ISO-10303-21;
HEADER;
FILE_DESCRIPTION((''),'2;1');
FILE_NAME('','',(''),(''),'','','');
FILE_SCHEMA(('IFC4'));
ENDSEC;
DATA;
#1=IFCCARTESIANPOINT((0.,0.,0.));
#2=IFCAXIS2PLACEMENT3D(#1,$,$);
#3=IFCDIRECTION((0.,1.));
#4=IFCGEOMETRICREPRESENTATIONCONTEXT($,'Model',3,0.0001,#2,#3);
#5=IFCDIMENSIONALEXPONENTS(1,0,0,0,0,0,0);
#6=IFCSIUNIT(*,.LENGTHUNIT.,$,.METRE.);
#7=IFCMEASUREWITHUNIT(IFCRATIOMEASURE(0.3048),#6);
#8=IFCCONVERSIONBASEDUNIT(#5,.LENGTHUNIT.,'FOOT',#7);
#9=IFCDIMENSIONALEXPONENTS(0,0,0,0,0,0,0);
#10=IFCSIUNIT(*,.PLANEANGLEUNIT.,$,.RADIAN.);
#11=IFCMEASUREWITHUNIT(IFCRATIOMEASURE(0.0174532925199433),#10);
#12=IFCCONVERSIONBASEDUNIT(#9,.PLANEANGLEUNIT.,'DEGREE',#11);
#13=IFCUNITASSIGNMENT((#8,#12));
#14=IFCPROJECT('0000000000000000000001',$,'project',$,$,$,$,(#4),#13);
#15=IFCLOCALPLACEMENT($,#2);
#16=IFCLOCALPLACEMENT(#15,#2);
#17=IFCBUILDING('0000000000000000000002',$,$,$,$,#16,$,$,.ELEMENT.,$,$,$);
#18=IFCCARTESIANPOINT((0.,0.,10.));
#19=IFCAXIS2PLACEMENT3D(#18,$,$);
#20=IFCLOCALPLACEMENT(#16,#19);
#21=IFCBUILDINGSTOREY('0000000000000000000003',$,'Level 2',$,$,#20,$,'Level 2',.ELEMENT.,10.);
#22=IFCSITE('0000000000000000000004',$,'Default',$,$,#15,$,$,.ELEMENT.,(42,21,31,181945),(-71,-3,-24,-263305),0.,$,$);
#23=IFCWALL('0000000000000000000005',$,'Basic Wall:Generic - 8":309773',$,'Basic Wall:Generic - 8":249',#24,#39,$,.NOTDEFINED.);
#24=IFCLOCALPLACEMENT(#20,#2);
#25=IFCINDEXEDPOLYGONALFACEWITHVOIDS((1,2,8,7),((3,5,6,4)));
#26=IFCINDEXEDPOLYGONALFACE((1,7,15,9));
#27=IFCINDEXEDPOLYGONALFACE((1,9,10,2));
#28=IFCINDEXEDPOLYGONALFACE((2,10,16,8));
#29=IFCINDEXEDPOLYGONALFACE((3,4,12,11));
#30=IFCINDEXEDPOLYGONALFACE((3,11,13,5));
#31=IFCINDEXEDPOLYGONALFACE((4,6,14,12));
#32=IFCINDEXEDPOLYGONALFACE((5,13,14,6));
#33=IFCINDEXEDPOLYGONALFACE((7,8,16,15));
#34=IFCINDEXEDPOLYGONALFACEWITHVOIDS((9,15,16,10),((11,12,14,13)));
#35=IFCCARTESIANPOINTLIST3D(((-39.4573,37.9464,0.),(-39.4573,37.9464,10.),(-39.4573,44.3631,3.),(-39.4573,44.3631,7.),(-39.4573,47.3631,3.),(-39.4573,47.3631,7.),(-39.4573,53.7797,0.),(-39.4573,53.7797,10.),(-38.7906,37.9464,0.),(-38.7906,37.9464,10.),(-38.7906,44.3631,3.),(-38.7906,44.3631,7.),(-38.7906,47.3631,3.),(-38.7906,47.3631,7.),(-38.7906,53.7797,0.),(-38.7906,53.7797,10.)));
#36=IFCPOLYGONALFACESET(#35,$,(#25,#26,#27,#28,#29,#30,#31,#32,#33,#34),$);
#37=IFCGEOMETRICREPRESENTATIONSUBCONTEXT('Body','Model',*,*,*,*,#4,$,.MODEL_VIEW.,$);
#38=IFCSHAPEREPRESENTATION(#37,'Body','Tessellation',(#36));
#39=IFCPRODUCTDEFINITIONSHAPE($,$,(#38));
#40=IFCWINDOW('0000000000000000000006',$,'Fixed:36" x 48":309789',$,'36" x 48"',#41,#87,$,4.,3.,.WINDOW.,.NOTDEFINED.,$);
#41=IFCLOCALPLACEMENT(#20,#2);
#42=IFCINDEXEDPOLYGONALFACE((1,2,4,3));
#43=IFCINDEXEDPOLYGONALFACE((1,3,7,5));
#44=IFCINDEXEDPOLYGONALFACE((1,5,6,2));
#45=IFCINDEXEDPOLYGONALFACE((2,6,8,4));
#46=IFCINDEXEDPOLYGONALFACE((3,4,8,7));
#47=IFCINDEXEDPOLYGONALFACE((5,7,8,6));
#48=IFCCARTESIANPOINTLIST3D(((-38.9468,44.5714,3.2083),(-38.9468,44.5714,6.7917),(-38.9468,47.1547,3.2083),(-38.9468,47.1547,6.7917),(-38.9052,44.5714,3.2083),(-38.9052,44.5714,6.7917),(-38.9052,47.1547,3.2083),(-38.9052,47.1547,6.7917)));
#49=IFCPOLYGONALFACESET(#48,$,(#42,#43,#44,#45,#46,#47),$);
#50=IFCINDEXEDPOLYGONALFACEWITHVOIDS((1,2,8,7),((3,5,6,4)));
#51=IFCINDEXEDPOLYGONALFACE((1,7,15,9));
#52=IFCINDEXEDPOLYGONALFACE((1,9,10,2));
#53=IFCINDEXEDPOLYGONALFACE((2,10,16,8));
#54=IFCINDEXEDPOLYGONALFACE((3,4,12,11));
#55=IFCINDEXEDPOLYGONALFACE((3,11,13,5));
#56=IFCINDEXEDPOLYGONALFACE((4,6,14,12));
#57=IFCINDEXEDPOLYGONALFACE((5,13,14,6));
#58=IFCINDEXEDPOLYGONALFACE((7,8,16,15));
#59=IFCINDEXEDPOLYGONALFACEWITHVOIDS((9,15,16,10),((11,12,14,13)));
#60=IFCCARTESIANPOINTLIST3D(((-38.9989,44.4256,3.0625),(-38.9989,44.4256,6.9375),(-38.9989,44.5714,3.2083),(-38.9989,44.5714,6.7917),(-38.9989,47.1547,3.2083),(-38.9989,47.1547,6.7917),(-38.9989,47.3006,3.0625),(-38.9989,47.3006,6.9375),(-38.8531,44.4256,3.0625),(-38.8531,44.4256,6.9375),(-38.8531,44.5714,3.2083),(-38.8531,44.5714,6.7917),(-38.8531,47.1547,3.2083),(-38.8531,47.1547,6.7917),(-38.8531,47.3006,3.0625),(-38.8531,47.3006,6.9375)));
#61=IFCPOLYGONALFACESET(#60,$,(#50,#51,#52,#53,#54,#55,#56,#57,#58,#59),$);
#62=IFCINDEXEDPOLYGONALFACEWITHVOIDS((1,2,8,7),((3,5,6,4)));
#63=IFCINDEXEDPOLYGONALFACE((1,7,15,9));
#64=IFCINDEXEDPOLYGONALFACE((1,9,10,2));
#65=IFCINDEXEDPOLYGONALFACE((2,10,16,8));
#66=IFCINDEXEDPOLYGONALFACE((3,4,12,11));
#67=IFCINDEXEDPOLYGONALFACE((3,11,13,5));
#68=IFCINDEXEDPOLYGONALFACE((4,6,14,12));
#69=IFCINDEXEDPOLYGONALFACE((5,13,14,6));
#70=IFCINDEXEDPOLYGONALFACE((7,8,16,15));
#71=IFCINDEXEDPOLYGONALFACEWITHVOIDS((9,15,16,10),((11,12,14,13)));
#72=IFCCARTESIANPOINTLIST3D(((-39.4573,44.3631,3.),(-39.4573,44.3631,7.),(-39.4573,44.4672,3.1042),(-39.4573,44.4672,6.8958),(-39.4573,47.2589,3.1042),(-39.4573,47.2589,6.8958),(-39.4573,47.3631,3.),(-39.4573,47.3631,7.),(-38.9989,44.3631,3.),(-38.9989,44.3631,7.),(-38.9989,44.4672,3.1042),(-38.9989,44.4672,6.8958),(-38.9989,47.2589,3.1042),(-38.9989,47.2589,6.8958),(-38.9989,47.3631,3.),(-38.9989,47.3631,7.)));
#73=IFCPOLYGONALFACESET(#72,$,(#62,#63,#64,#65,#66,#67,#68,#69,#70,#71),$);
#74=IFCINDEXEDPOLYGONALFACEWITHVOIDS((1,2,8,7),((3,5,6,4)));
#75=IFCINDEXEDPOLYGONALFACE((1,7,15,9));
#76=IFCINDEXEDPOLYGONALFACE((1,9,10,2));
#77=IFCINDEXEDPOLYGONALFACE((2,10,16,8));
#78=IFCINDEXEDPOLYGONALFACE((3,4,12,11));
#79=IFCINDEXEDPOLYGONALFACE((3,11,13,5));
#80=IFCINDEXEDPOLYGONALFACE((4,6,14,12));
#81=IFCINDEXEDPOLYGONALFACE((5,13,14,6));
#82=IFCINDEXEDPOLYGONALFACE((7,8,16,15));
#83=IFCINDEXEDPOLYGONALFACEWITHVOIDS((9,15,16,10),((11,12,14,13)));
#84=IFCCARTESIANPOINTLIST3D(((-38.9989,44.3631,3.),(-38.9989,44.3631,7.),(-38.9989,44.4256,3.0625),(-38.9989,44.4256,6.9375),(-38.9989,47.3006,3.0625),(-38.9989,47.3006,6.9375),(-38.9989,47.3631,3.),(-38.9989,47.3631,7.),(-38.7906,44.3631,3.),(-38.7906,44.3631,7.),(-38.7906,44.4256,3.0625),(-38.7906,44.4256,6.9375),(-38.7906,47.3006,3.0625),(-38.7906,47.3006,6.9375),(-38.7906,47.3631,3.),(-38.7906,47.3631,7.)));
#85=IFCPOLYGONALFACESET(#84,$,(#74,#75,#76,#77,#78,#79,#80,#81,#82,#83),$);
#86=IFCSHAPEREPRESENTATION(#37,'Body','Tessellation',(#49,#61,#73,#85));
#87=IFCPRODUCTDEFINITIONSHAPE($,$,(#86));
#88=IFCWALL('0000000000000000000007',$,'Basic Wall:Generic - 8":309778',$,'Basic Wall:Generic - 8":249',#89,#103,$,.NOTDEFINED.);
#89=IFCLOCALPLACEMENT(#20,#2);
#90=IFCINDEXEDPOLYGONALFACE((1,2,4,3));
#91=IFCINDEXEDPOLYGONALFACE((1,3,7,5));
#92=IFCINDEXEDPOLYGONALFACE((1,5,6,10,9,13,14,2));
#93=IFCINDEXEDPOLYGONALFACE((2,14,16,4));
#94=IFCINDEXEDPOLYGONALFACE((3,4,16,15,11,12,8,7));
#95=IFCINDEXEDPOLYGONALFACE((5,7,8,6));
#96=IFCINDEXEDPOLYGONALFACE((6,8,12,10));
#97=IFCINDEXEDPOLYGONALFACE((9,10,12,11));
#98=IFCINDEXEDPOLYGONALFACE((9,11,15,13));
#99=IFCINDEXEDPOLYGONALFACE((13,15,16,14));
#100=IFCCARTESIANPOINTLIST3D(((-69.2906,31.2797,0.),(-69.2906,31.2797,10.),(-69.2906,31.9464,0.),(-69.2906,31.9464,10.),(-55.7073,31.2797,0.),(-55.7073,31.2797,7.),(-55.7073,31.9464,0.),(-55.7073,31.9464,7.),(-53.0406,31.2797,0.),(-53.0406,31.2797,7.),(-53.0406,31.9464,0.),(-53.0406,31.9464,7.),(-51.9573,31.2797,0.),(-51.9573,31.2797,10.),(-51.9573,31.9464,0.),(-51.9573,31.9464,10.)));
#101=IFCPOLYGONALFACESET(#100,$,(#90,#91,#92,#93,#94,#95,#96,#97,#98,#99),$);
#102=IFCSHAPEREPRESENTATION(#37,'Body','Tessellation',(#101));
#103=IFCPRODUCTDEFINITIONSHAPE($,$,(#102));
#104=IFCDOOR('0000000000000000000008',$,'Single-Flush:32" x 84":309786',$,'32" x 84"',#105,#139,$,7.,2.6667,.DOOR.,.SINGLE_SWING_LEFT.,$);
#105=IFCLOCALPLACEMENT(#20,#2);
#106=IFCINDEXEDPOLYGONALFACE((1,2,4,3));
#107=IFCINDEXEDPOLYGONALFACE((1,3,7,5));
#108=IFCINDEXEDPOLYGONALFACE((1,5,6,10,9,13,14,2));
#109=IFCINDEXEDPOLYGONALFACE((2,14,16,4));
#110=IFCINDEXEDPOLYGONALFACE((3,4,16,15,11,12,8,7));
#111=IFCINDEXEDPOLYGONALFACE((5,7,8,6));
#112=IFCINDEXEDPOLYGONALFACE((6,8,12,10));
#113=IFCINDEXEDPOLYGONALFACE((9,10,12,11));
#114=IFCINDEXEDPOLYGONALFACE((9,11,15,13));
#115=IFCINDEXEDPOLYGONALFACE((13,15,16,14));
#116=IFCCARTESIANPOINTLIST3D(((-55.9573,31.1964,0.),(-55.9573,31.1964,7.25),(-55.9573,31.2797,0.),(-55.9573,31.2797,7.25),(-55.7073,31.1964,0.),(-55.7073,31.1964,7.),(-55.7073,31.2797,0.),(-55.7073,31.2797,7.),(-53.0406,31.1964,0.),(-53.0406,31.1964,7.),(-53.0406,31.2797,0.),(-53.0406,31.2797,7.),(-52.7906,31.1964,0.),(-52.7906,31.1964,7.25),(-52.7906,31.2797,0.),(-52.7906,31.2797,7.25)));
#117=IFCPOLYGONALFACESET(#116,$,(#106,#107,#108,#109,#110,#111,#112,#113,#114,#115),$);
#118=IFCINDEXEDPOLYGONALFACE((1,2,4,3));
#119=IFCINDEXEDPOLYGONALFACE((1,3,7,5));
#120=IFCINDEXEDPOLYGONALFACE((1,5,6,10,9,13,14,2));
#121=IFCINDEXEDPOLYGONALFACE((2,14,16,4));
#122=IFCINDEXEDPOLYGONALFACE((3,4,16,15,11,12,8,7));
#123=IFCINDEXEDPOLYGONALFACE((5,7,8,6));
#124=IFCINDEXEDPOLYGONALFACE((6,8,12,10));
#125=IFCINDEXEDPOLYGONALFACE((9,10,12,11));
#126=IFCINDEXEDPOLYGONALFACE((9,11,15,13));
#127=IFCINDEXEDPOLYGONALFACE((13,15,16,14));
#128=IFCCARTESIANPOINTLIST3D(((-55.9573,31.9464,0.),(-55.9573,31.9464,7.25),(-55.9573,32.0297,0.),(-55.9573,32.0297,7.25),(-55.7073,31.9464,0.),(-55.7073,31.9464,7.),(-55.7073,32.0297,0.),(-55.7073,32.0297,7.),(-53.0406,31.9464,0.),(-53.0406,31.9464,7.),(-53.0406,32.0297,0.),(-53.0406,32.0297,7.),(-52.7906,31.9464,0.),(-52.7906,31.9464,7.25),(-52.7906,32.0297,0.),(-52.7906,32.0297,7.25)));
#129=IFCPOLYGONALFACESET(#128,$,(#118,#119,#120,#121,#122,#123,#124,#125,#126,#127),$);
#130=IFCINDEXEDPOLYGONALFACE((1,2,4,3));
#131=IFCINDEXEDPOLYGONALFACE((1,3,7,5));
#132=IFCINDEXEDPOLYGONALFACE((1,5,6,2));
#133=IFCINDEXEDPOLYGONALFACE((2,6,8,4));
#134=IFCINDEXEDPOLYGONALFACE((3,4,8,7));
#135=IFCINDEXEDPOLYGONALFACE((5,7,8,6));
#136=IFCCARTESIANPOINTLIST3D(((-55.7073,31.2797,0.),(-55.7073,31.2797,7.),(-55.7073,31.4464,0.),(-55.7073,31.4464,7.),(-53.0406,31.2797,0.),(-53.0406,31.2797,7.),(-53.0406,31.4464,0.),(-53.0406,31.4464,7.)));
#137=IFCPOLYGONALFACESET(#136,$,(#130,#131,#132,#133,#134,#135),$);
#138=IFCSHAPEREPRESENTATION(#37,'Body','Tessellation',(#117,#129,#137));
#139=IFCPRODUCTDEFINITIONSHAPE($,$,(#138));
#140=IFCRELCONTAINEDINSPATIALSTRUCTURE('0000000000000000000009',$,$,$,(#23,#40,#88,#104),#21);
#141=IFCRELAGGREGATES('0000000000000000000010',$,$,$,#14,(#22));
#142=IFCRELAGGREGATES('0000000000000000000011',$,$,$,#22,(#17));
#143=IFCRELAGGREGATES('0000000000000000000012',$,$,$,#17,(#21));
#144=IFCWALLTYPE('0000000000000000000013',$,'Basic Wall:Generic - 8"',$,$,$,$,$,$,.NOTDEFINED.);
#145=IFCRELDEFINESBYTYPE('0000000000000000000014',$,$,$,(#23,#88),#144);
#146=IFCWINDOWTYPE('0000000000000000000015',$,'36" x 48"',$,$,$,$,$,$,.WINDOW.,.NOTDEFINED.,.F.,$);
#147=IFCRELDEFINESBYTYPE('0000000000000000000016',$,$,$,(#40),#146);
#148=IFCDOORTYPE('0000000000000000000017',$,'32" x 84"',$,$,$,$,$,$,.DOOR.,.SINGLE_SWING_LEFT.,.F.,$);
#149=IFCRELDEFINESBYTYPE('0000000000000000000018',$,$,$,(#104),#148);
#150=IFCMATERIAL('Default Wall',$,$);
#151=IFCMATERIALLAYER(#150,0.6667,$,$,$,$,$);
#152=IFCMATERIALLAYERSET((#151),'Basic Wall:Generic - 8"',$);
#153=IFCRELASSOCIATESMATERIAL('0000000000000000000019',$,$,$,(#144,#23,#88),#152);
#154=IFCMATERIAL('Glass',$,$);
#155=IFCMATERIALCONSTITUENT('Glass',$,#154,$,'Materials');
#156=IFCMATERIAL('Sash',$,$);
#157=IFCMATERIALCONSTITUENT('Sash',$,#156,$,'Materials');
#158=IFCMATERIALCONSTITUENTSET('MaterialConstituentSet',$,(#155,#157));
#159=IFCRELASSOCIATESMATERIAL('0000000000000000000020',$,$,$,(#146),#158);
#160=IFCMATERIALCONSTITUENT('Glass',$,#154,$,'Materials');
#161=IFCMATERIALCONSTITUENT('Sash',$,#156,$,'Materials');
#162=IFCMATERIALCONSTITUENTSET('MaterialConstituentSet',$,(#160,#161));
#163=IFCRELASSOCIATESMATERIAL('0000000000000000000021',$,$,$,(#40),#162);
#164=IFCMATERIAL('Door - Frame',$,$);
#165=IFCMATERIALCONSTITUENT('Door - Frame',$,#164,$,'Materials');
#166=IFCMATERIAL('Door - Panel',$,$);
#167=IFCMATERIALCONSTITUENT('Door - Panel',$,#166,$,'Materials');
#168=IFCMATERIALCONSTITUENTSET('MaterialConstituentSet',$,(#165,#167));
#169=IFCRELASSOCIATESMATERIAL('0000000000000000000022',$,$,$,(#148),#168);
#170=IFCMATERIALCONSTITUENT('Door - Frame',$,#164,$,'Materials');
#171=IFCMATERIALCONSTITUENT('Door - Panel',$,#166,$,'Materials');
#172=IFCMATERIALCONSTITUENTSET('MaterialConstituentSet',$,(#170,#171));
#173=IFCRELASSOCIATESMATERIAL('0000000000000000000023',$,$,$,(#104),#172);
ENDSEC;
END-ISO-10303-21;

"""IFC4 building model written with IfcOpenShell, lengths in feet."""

from ifc_helpers import new_model, entity, si_unit, converted_unit, direction, frame, frame_2d, origin, place, context, subcontext, project, spatial, polyline, rectangle, outline, extrude, source, transform, mapped, material, layer, layer_set, layer_usage, constituent, constituent_set, type_object, type_shapes, element, fill, save


model = new_model("IFC4")

# Units and contexts
model_context = context("Model", 3, precision=0.0001, world=origin(), true_north=direction((0.0, 1.0)))
body_context = subcontext(model_context, "Body", "Model", "MODEL_VIEW")
ifc_project = project(units=[converted_unit("LENGTHUNIT", "FOOT", entity("IfcRatioMeasure", 0.3048), si_unit("LENGTHUNIT", "METRE"), dimensions=[1, 0, 0, 0, 0, 0, 0]), converted_unit("PLANEANGLEUNIT", "DEGREE", entity("IfcRatioMeasure", 0.0174532925199433), si_unit("PLANEANGLEUNIT", "RADIAN"), dimensions=[0, 0, 0, 0, 0, 0, 0])], contexts=[model_context])

# Site, building, storey
site_placement = place(None, origin())
site = spatial("IfcSite", under=ifc_project, at=site_placement, Name="Default", CompositionType="ELEMENT", RefLatitude=(42, 21, 31, 181945), RefLongitude=(-71, -3, -24, -263305), RefElevation=0.0)
building_placement = place(site_placement, origin())
building = spatial("IfcBuilding", under=site, at=building_placement, CompositionType="ELEMENT")
storey_placement = place(building_placement, frame((0.0, 0.0, 10.0)))
storey = spatial("IfcBuildingStorey", under=building, at=storey_placement, Name="Level 2", LongName="Level 2", CompositionType="ELEMENT", Elevation=10.0)

# Shared definitions
ifc_material_1 = material(Name="Default Wall")
ifc_layer = layer(ifc_material_1, 0.6667)
ifc_layer_set = layer_set([ifc_layer], Name="Basic Wall:Generic - 8\"")
wall_type = type_object("IfcWallType", Name="Basic Wall:Generic - 8\"", PredefinedType="NOTDEFINED", material=ifc_layer_set)
ifc_material_2 = material(Name="Glass")
ifc_material_3 = material(Name="Sash")
ifc_constituent_1 = constituent(ifc_material_2, Name="Glass", Category="Materials")
ifc_constituent_2 = constituent(ifc_material_3, Name="Sash", Category="Materials")
ifc_constituent_set_1 = constituent_set(constituents=[ifc_constituent_1, ifc_constituent_2], Name="MaterialConstituentSet")
window_type_1 = type_object("IfcWindowType", Name="36\" x 48\"", ParameterTakesPrecedence=False, PartitioningType="NOTDEFINED", PredefinedType="WINDOW", material=ifc_constituent_set_1)
shared_shape_1 = source(origin(), body_context, "Body", "SweptSolid", [
    extrude(rectangle(XDim=0.0417, YDim=2.5833, at=frame_2d((0.0, 0.0), x_axis=(1.0, 0.0))), frame((1.5, 0.5312, 0.2083), z_axis=(0.0, 0.0, 1.0), x_axis=(0.0, 1.0, 0.0)), (0.0, 0.0, 1.0), 3.5833),
    extrude(outline(polyline([(-1.4375, -1.9375), (1.4375, -1.9375), (1.4375, 1.9375), (-1.4375, 1.9375), (-1.4375, -1.9375)]), holes=[polyline([(-1.2917, -1.7917), (-1.2917, 1.7917), (1.2917, 1.7917), (1.2917, -1.7917), (-1.2917, -1.7917)])]), frame((1.5, 0.4583, 2.0), z_axis=(0.0, 1.0, 0.0), x_axis=(1.0, 0.0, 0.0)), (0.0, 0.0, 1.0), 0.1458),
    extrude(outline(polyline([(-1.5, -2.0), (1.5, -2.0), (1.5, 2.0), (-1.5, 2.0), (-1.5, -2.0)]), holes=[polyline([(-1.3958, -1.8958), (-1.3958, 1.8958), (1.3958, 1.8958), (1.3958, -1.8958), (-1.3958, -1.8958)])]), frame((1.5, 0.0, 2.0), z_axis=(0.0, 1.0, 0.0), x_axis=(1.0, 0.0, 0.0)), (0.0, 0.0, 1.0), 0.4583),
    extrude(outline(polyline([(-2.0, -1.5), (2.0, -1.5), (2.0, 1.5), (-2.0, 1.5), (-2.0, -1.5)]), holes=[polyline([(-1.9375, -1.4375), (-1.9375, 1.4375), (1.9375, 1.4375), (1.9375, -1.4375), (-1.9375, -1.4375)])]), frame((1.5, 0.4583, 2.0), z_axis=(0.0, 1.0, 0.0), x_axis=(0.0, 0.0, -1.0)), (0.0, 0.0, 1.0), 0.2083),
])
type_shapes(window_type_1, [shared_shape_1])

# Shared definitions
ifc_material_4 = material(Name="Door - Frame")
ifc_material_5 = material(Name="Door - Panel")

# Wall, opening, window
ifc_layer_usage_1 = layer_usage(ifc_layer_set, "AXIS2", "NEGATIVE", 0.3333)
wall_1_placement = place(storey_placement, frame((-39.1239, 37.9464, 0.0), z_axis=(0.0, 0.0, 1.0), x_axis=(0.0, 1.0, 0.0)))
wall_1 = element("IfcWall", 1, at=wall_1_placement, inside=storey, type_object=wall_type, material=ifc_layer_usage_1, Name="Basic Wall:Generic - 8\":309773", ObjectType="Basic Wall:Generic - 8\":249", PredefinedType="NOTDEFINED", context=body_context, shape_type="SweptSolid", body=[
    extrude(rectangle(XDim=15.8333, YDim=0.6667, at=frame_2d((7.9167, 0.0), x_axis=(-1.0, 0.0))), origin(), (0.0, 0.0, 1.0), 10.0),
])
opening_1_placement = place(wall_1_placement, frame((9.4167, 0.3333, 3.0)))
opening_1 = element("IfcOpeningElement", 2, at=opening_1_placement, cuts=wall_1, ObjectType="Opening", PredefinedType="OPENING", context=body_context, shape_type="SweptSolid", body=[
    extrude(rectangle(XDim=4.0, YDim=3.0, at=frame_2d((2.0, 1.5), x_axis=(-1.0, 0.0))), frame((0.0, 0.0, 0.0), z_axis=(0.0, -1.0, 0.0), x_axis=(0.0, 0.0, 1.0)), (0.0, 0.0, 1.0), 0.6667),
])
ifc_constituent_3 = constituent(ifc_material_2, Name="Glass", Category="Materials")
ifc_constituent_4 = constituent(ifc_material_3, Name="Sash", Category="Materials")
ifc_constituent_set_2 = constituent_set(constituents=[ifc_constituent_3, ifc_constituent_4], Name="MaterialConstituentSet")
window_1_placement = place(opening_1_placement, frame((0.0, 0.0, 0.0), z_axis=(0.0, 0.0, 1.0), x_axis=(-1.0, 0.0, 0.0)))
window_1 = element("IfcWindow", 3, at=window_1_placement, inside=storey, type_object=window_type_1, material=ifc_constituent_set_2, Name="Fixed:36\" x 48\":309789", ObjectType="36\" x 48\"", OverallHeight=4.0, OverallWidth=3.0, PartitioningType="NOTDEFINED", PredefinedType="WINDOW", context=body_context, shape_type="MappedRepresentation", body=[
    mapped(shared_shape_1, transform((0.0, 0.0, 0.0), scale=1.0)),
])
fill(opening_1, window_1)

# Wall, opening, door
ifc_layer_usage_2 = layer_usage(ifc_layer_set, "AXIS2", "NEGATIVE", 0.3333)
wall_2_placement = place(storey_placement, frame((-51.9573, 31.6131, 0.0), z_axis=(0.0, 0.0, 1.0), x_axis=(-1.0, 0.0, 0.0)))
wall_2 = element("IfcWall", 4, at=wall_2_placement, inside=storey, type_object=wall_type, material=ifc_layer_usage_2, Name="Basic Wall:Generic - 8\":309778", ObjectType="Basic Wall:Generic - 8\":249", PredefinedType="NOTDEFINED", context=body_context, shape_type="SweptSolid", body=[
    extrude(rectangle(XDim=17.3333, YDim=0.6667, at=frame_2d((8.6667, 0.0), x_axis=(-1.0, 0.0))), origin(), (0.0, 0.0, 1.0), 10.0),
])
opening_2_placement = place(wall_2_placement, frame((1.0833, -0.3333, 0.0)))
opening_2 = element("IfcOpeningElement", 5, at=opening_2_placement, cuts=wall_2, ObjectType="Opening", PredefinedType="OPENING", context=body_context, shape_type="SweptSolid", body=[
    extrude(rectangle(XDim=2.6667, YDim=7.0, at=frame_2d((3.5, 1.3333), x_axis=(0.0, -1.0))), frame((0.0, 0.0, 0.0), z_axis=(0.0, 1.0, 0.0), x_axis=(0.0, 0.0, 1.0)), (0.0, 0.0, 1.0), 0.6667),
])
ifc_constituent_5 = constituent(ifc_material_4, Name="Door - Frame", Category="Materials")
ifc_constituent_6 = constituent(ifc_material_5, Name="Door - Panel", Category="Materials")
ifc_constituent_set_3 = constituent_set(constituents=[ifc_constituent_5, ifc_constituent_6], Name="MaterialConstituentSet")
ifc_constituent_7 = constituent(ifc_material_4, Name="Door - Frame", Category="Materials")
ifc_constituent_8 = constituent(ifc_material_5, Name="Door - Panel", Category="Materials")
ifc_constituent_set_4 = constituent_set(constituents=[ifc_constituent_7, ifc_constituent_8], Name="MaterialConstituentSet")
door_type_1 = type_object("IfcDoorType", Name="32\" x 84\"", OperationType="SINGLE_SWING_LEFT", ParameterTakesPrecedence=False, PredefinedType="DOOR", material=ifc_constituent_set_4)
shared_shape_2 = source(origin(), body_context, "Body", "SweptSolid", [
    extrude(outline(polyline([(-1.5833, -3.6875), (1.5833, -3.6875), (1.5833, 3.5625), (1.3333, 3.5625), (1.3333, -3.4375), (-1.3333, -3.4375), (-1.3333, 3.5625), (-1.5833, 3.5625), (-1.5833, -3.6875)])), frame((1.3333, 0.75, 3.5625), z_axis=(0.0, -1.0, 0.0), x_axis=(-1.0, 0.0, 0.0)), (0.0, 0.0, 1.0), 0.0833),
    extrude(outline(polyline([(-3.6875, -1.5833), (3.5625, -1.5833), (3.5625, -1.3333), (-3.4375, -1.3333), (-3.4375, 1.3333), (3.5625, 1.3333), (3.5625, 1.5833), (-3.6875, 1.5833), (-3.6875, -1.5833)])), frame((1.3333, 0.0, 3.5625), z_axis=(0.0, -1.0, 0.0), x_axis=(0.0, 0.0, -1.0)), (0.0, 0.0, 1.0), 0.0833),
    extrude(rectangle(XDim=2.6667, YDim=0.1667, at=frame_2d((0.0, 0.0), x_axis=(1.0, 0.0))), frame((1.3333, 0.5833, 0.0)), (0.0, 0.0, 1.0), 7.0),
])
type_shapes(door_type_1, [shared_shape_2])
door_1_placement = place(opening_2_placement, origin())
door_1 = element("IfcDoor", 6, at=door_1_placement, inside=storey, type_object=door_type_1, material=ifc_constituent_set_3, Name="Single-Flush:32\" x 84\":309786", ObjectType="32\" x 84\"", OperationType="SINGLE_SWING_LEFT", OverallHeight=7.0, OverallWidth=2.6667, PredefinedType="DOOR", context=body_context, shape_type="MappedRepresentation", body=[
    mapped(shared_shape_2, transform((0.0, 0.0, 0.0), scale=1.0)),
])
fill(opening_2, door_1)

save(model, "model.ifc")
